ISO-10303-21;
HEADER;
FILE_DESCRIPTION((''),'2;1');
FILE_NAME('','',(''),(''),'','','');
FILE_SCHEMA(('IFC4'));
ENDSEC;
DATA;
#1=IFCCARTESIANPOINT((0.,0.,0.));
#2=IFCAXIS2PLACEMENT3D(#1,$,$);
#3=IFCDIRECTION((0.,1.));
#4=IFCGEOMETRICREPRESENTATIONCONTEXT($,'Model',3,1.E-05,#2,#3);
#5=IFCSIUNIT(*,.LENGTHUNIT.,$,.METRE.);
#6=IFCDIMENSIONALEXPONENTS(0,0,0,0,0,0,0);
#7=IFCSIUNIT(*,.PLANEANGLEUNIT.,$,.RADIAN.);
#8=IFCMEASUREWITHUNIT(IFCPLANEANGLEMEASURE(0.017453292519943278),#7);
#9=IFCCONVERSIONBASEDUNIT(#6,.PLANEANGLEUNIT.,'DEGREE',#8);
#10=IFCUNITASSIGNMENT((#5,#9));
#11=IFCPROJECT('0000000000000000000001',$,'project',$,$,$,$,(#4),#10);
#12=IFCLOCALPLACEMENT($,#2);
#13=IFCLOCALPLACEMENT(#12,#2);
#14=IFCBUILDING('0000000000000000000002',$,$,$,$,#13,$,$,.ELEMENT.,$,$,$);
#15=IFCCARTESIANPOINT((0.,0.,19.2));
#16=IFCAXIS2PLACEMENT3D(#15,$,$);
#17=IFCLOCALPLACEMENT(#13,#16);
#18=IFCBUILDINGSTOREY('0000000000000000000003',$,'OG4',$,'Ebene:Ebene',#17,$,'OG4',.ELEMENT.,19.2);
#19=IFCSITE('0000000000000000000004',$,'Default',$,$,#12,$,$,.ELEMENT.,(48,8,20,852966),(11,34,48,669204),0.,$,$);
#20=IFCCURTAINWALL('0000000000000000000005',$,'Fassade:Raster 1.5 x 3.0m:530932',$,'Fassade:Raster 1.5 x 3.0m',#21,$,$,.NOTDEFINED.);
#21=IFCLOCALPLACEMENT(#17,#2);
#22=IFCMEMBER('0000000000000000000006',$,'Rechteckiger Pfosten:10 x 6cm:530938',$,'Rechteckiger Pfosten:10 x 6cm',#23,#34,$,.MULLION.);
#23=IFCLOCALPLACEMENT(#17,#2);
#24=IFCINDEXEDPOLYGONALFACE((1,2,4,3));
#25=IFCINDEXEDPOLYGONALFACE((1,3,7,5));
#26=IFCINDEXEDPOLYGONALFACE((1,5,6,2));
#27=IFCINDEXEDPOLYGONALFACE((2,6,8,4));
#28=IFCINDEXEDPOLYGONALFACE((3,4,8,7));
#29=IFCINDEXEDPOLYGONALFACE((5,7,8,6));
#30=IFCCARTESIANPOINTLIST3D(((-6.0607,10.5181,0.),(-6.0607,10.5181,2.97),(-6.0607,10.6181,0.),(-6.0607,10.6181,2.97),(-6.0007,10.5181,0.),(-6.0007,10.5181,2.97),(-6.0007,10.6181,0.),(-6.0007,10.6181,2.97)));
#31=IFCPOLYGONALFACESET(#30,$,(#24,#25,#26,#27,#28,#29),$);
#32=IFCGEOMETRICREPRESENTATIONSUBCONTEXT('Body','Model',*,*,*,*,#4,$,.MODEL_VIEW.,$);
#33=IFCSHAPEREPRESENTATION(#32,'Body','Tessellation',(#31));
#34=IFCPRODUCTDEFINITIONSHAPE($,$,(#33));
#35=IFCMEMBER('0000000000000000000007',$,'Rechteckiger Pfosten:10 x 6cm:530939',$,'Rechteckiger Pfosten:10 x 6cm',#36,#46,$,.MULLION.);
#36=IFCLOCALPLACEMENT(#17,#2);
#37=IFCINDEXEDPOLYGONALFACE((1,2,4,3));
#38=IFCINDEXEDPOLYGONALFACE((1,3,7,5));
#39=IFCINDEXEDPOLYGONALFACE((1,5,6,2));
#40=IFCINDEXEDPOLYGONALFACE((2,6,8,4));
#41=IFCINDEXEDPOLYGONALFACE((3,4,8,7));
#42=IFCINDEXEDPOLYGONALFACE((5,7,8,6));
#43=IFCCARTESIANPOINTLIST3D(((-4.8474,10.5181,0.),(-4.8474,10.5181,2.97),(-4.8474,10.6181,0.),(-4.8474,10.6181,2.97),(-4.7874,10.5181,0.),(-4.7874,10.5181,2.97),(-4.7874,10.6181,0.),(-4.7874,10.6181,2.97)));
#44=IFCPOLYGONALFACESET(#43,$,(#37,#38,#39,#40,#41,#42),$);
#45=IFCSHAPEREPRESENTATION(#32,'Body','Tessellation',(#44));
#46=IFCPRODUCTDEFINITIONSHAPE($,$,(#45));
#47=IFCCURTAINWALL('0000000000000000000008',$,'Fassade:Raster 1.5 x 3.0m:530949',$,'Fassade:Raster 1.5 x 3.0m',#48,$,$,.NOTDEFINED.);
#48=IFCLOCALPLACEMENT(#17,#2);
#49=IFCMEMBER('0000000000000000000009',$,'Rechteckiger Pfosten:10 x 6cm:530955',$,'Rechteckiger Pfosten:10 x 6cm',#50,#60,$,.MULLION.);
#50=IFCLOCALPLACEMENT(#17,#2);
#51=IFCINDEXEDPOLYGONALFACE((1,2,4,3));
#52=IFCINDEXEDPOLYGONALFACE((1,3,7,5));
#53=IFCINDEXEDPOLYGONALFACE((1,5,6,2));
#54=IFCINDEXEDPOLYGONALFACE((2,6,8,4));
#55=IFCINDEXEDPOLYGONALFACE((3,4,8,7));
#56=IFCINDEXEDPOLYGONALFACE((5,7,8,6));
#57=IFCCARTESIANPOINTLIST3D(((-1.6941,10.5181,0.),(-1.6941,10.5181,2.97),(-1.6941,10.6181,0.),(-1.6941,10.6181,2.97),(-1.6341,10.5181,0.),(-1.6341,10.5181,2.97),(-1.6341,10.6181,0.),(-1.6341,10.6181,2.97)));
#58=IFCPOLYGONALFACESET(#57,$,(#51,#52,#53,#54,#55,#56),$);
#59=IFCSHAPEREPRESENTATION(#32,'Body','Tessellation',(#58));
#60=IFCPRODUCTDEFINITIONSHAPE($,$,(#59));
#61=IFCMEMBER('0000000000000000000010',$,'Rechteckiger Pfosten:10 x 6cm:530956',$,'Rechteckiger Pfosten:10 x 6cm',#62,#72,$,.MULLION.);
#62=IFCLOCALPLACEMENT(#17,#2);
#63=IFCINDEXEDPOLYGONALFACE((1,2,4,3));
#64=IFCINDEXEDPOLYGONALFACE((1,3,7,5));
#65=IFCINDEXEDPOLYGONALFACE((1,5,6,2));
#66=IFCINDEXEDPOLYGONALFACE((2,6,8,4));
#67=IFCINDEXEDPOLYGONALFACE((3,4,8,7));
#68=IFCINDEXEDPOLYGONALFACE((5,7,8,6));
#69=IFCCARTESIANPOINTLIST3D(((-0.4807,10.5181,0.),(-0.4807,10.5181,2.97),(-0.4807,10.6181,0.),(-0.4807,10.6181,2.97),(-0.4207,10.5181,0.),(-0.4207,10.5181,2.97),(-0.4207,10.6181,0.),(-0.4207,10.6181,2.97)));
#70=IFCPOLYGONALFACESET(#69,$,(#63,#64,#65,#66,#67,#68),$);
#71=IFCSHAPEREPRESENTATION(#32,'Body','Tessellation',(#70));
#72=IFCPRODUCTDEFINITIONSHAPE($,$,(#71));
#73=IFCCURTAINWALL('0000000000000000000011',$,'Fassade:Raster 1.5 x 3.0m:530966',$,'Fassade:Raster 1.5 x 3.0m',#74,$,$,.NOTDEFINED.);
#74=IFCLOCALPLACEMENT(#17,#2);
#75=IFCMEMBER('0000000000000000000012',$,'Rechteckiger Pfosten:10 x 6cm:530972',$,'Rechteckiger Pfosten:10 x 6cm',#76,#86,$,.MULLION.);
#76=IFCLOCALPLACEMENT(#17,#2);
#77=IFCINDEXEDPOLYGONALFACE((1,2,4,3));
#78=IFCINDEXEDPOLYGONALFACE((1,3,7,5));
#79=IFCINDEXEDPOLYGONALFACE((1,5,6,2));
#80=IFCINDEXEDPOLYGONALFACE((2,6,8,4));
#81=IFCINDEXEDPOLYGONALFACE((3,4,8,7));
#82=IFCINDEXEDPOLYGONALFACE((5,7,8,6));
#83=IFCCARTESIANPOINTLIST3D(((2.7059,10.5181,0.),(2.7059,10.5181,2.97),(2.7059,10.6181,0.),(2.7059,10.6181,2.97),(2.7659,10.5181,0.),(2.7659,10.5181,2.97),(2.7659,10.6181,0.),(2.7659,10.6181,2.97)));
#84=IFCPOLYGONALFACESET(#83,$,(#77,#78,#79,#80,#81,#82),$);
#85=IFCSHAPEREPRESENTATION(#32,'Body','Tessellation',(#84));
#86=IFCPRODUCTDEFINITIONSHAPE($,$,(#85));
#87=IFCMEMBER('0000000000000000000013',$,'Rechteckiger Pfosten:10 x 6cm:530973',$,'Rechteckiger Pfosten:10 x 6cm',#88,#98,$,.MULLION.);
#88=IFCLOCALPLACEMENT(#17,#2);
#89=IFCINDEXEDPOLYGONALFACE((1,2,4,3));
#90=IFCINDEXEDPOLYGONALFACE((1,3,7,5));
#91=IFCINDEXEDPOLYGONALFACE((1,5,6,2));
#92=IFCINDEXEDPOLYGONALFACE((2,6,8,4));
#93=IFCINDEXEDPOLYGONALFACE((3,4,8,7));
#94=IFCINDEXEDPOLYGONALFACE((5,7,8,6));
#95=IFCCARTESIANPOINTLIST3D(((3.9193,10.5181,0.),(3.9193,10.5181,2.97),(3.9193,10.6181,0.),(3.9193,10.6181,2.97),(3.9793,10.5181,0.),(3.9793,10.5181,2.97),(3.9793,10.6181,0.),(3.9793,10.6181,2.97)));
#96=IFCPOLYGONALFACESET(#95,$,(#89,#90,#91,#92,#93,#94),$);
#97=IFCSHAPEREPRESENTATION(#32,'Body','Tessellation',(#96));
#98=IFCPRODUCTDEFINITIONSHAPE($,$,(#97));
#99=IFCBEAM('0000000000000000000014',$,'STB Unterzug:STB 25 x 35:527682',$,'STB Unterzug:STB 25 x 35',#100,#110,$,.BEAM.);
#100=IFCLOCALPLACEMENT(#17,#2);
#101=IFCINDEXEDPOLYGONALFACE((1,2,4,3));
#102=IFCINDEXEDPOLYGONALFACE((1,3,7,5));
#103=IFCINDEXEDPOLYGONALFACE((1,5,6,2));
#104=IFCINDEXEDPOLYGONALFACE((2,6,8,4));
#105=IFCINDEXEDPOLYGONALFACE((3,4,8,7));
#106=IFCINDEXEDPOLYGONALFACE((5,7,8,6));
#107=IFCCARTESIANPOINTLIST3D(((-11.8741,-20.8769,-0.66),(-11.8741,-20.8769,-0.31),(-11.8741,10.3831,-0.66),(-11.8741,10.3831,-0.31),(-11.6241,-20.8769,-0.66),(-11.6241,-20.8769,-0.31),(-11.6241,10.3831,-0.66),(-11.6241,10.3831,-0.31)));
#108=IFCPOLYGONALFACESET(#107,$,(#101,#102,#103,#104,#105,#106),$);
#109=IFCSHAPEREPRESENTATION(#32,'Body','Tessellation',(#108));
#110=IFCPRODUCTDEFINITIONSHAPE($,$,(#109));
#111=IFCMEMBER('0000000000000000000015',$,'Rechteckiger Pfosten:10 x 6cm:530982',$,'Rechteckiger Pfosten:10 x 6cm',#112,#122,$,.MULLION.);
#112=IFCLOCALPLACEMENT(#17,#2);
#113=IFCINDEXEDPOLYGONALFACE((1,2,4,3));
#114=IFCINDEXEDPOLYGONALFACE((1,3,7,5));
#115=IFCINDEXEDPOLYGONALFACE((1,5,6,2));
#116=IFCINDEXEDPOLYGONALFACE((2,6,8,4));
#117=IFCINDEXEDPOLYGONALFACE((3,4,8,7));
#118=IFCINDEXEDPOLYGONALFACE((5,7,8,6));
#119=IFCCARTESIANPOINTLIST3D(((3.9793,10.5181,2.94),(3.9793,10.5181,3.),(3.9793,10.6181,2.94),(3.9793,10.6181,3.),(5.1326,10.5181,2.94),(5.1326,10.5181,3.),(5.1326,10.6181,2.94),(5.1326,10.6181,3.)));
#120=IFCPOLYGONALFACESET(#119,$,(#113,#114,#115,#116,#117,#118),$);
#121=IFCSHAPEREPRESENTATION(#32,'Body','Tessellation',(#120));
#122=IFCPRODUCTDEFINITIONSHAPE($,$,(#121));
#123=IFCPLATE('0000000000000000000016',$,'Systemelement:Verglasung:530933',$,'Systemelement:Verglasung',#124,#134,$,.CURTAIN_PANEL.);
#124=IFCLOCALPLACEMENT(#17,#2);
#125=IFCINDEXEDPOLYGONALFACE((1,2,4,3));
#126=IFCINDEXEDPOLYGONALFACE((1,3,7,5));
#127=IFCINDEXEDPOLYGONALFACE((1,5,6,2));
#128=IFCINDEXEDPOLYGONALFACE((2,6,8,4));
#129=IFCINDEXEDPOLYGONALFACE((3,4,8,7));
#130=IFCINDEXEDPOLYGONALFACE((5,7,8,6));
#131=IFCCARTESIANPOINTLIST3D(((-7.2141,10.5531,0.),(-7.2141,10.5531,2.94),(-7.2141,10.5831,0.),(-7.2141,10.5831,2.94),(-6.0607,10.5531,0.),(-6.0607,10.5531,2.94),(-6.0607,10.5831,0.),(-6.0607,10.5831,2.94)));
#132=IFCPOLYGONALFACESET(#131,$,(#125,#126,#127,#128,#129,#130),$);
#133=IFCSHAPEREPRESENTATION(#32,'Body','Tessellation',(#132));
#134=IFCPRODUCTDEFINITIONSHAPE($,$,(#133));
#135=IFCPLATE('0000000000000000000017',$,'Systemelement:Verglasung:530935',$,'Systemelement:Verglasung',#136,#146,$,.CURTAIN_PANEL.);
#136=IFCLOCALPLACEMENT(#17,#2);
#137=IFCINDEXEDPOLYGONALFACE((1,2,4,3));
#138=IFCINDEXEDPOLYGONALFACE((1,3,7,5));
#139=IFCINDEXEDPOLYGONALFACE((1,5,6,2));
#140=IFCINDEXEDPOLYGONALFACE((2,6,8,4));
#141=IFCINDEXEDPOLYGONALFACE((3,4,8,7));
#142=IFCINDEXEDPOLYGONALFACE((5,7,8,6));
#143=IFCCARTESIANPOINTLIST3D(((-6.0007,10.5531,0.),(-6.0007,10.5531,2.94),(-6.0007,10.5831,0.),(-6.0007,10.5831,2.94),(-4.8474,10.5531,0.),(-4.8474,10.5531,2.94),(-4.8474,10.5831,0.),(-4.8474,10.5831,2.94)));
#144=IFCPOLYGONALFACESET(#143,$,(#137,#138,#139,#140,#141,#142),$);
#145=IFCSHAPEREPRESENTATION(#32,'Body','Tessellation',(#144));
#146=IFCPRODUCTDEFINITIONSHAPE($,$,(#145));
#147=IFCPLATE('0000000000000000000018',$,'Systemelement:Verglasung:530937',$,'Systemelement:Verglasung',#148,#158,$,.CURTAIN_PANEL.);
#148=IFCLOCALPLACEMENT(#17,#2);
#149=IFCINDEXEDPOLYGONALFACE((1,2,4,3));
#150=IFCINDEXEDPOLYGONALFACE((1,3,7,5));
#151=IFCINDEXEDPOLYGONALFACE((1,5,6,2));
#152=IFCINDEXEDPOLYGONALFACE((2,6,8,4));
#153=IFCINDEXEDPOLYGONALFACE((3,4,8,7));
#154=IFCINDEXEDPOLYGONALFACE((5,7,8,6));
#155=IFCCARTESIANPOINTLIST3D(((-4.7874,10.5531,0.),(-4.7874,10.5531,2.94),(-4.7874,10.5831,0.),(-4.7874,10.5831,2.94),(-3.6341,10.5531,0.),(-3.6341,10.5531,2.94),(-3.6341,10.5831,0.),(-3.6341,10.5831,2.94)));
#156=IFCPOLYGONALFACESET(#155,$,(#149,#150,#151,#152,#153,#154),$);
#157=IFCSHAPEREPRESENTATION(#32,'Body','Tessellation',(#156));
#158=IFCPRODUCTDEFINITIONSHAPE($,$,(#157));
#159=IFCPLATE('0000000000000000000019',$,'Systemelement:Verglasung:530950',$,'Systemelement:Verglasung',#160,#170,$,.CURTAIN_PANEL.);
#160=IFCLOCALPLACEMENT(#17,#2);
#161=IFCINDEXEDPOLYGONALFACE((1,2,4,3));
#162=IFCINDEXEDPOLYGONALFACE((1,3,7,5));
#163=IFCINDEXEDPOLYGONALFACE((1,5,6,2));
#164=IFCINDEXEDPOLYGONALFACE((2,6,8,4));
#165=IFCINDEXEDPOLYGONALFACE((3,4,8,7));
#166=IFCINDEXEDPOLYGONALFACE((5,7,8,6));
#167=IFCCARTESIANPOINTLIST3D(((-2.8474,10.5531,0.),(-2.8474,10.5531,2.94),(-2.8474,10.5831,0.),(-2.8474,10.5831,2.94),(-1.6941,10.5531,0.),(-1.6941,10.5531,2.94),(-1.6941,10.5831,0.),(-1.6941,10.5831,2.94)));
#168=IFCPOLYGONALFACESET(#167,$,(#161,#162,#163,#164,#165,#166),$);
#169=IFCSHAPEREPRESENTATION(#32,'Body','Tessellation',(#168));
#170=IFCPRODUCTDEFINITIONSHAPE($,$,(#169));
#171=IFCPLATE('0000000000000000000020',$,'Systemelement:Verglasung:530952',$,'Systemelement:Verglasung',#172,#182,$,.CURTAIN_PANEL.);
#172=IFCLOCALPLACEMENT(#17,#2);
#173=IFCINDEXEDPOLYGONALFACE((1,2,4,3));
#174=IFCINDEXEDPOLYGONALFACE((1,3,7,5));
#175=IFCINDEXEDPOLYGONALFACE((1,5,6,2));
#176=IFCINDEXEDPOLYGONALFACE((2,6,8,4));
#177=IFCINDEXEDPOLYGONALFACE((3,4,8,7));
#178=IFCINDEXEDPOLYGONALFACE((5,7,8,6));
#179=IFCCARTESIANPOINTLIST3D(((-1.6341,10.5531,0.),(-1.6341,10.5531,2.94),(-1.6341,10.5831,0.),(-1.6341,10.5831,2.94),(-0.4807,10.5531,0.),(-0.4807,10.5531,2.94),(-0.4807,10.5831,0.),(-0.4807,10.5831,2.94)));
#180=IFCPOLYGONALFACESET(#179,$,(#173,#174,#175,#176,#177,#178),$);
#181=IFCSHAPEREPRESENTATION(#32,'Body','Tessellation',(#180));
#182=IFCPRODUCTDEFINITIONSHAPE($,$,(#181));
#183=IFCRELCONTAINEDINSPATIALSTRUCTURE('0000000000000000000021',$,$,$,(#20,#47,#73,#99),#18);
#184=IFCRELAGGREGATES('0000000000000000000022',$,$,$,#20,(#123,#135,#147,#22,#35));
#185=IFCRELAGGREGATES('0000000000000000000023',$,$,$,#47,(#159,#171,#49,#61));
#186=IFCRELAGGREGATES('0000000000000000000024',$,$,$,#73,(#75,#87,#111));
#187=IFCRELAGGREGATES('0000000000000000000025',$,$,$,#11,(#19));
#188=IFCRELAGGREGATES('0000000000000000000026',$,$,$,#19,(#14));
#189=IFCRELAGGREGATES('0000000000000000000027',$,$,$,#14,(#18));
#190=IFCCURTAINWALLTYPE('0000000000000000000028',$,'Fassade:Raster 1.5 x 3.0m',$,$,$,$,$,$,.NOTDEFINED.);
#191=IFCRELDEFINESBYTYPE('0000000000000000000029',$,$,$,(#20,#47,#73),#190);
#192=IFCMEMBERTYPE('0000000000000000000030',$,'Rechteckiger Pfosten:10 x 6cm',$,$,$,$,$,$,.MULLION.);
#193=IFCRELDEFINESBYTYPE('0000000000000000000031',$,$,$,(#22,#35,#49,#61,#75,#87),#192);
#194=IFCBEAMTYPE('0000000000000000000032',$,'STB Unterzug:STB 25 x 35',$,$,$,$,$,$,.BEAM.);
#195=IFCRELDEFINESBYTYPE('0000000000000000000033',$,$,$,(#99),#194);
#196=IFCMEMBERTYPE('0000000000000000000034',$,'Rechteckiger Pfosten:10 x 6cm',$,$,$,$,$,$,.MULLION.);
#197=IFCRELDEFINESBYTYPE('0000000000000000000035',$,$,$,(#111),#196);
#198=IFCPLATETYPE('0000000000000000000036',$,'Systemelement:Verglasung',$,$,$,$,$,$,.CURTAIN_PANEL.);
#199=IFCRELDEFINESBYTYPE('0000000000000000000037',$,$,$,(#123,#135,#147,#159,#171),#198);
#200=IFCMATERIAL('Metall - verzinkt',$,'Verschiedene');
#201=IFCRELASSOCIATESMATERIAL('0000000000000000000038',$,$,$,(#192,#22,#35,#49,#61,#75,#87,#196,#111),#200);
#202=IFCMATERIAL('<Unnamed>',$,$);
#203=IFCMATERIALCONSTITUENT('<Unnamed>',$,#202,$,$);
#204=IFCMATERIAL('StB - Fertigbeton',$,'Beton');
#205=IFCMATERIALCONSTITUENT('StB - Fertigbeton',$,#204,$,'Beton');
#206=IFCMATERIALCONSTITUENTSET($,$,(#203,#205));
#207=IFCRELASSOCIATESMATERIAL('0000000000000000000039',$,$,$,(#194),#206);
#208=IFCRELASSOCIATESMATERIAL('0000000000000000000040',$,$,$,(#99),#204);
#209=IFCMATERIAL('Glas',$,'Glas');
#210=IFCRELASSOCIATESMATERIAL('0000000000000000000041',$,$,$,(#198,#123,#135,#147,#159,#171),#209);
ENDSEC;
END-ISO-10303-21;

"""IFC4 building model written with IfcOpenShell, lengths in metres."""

from ifc_helpers import new_model, entity, si_unit, converted_unit, direction, frame, origin, place, context, subcontext, project, spatial, indexed_curve, outline, extrude, source, transform, mapped, material, constituent, constituent_set, type_object, type_shapes, element, aggregate, save


model = new_model("IFC4")

# Units and contexts
model_context = context("Model", 3, precision=1e-05, world=origin(), true_north=direction((0.0, 1.0)))
body_context = subcontext(model_context, "Body", "Model", "MODEL_VIEW")
ifc_project = project(units=[si_unit("LENGTHUNIT", "METRE"), converted_unit("PLANEANGLEUNIT", "DEGREE", entity("IfcPlaneAngleMeasure", 0.017453292519943278), si_unit("PLANEANGLEUNIT", "RADIAN"), dimensions=[0, 0, 0, 0, 0, 0, 0])], contexts=[model_context])

# Site, building, storey
site_placement = place(None, origin())
site = spatial("IfcSite", under=ifc_project, at=site_placement, Name="Default", CompositionType="ELEMENT", RefLatitude=(48, 8, 20, 852966), RefLongitude=(11, 34, 48, 669204), RefElevation=0.0)
building_placement = place(site_placement, origin())
building = spatial("IfcBuilding", under=site, at=building_placement, CompositionType="ELEMENT")
storey_placement = place(building_placement, frame((0.0, 0.0, 19.2)))
storey = spatial("IfcBuildingStorey", under=building, at=storey_placement, Name="OG4", ObjectType="Ebene:Ebene", LongName="OG4", CompositionType="ELEMENT", Elevation=19.2)

# Curtain walls, members
curtain_wall_type = type_object("IfcCurtainWallType", Name="Fassade:Raster 1.5 x 3.0m", PredefinedType="NOTDEFINED")
curtain_wall_1_placement = place(storey_placement, frame((0.0, 0.0, -19.2)))
curtain_wall_1 = element("IfcCurtainWall", 1, at=curtain_wall_1_placement, inside=storey, type_object=curtain_wall_type, Name="Fassade:Raster 1.5 x 3.0m:530932", ObjectType="Fassade:Raster 1.5 x 3.0m", PredefinedType="NOTDEFINED")
ifc_material_1 = material(Name="Metall - verzinkt", Category="Verschiedene")
member_type_1 = type_object("IfcMemberType", Name="Rechteckiger Pfosten:10 x 6cm", PredefinedType="MULLION", material=ifc_material_1)
shared_shape_1 = source(origin(), body_context, "Body", "SweptSolid", [
    extrude(outline(indexed_curve([(-0.03, -0.05), (0.03, -0.05), (0.03, 0.05), (-0.03, 0.05), (-0.03, -0.05)], self_intersect=False)), frame((0.0, 0.0, -2.97), z_axis=(0.0, 0.0, 1.0), x_axis=(-1.0, 0.0, 0.0)), (0.0, 0.0, 1.0), 2.97),
])
type_shapes(member_type_1, [shared_shape_1])
member_1_placement = place(curtain_wall_1_placement, frame((-6.0307, 10.5681, 19.2), z_axis=(0.0, 0.0, -1.0), x_axis=(1.0, 0.0, 0.0)))
member_1 = element("IfcMember", 2, at=member_1_placement, type_object=member_type_1, material=ifc_material_1, Name="Rechteckiger Pfosten:10 x 6cm:530938", ObjectType="Rechteckiger Pfosten:10 x 6cm", PredefinedType="MULLION", context=body_context, shape_type="MappedRepresentation", body=[
    mapped(shared_shape_1, transform((0.0, 0.0, 0.0), scale=1.0)),
])
member_2_placement = place(curtain_wall_1_placement, frame((-4.8174, 10.5681, 19.2), z_axis=(0.0, 0.0, -1.0), x_axis=(1.0, 0.0, 0.0)))
member_2 = element("IfcMember", 3, at=member_2_placement, type_object=member_type_1, material=ifc_material_1, Name="Rechteckiger Pfosten:10 x 6cm:530939", ObjectType="Rechteckiger Pfosten:10 x 6cm", PredefinedType="MULLION", context=body_context, shape_type="MappedRepresentation", body=[
    mapped(shared_shape_1, transform((0.0, 0.0, 0.0), scale=1.0)),
])
curtain_wall_2_placement = place(storey_placement, frame((0.0, 0.0, -19.2)))
curtain_wall_2 = element("IfcCurtainWall", 4, at=curtain_wall_2_placement, inside=storey, type_object=curtain_wall_type, Name="Fassade:Raster 1.5 x 3.0m:530949", ObjectType="Fassade:Raster 1.5 x 3.0m", PredefinedType="NOTDEFINED")
member_3_placement = place(curtain_wall_2_placement, frame((-1.6641, 10.5681, 19.2), z_axis=(0.0, 0.0, -1.0), x_axis=(1.0, 0.0, 0.0)))
member_3 = element("IfcMember", 5, at=member_3_placement, type_object=member_type_1, material=ifc_material_1, Name="Rechteckiger Pfosten:10 x 6cm:530955", ObjectType="Rechteckiger Pfosten:10 x 6cm", PredefinedType="MULLION", context=body_context, shape_type="MappedRepresentation", body=[
    mapped(shared_shape_1, transform((0.0, 0.0, 0.0), scale=1.0)),
])
member_4_placement = place(curtain_wall_2_placement, frame((-0.4507, 10.5681, 19.2), z_axis=(0.0, 0.0, -1.0), x_axis=(1.0, 0.0, 0.0)))
member_4 = element("IfcMember", 6, at=member_4_placement, type_object=member_type_1, material=ifc_material_1, Name="Rechteckiger Pfosten:10 x 6cm:530956", ObjectType="Rechteckiger Pfosten:10 x 6cm", PredefinedType="MULLION", context=body_context, shape_type="MappedRepresentation", body=[
    mapped(shared_shape_1, transform((0.0, 0.0, 0.0), scale=1.0)),
])
curtain_wall_3_placement = place(storey_placement, frame((0.0, 0.0, -19.2)))
curtain_wall_3 = element("IfcCurtainWall", 7, at=curtain_wall_3_placement, inside=storey, type_object=curtain_wall_type, Name="Fassade:Raster 1.5 x 3.0m:530966", ObjectType="Fassade:Raster 1.5 x 3.0m", PredefinedType="NOTDEFINED")
member_5_placement = place(curtain_wall_3_placement, frame((2.7359, 10.5681, 19.2), z_axis=(0.0, 0.0, -1.0), x_axis=(1.0, 0.0, 0.0)))
member_5 = element("IfcMember", 8, at=member_5_placement, type_object=member_type_1, material=ifc_material_1, Name="Rechteckiger Pfosten:10 x 6cm:530972", ObjectType="Rechteckiger Pfosten:10 x 6cm", PredefinedType="MULLION", context=body_context, shape_type="MappedRepresentation", body=[
    mapped(shared_shape_1, transform((0.0, 0.0, 0.0), scale=1.0)),
])
member_6_placement = place(curtain_wall_3_placement, frame((3.9493, 10.5681, 19.2), z_axis=(0.0, 0.0, -1.0), x_axis=(1.0, 0.0, 0.0)))
member_6 = element("IfcMember", 9, at=member_6_placement, type_object=member_type_1, material=ifc_material_1, Name="Rechteckiger Pfosten:10 x 6cm:530973", ObjectType="Rechteckiger Pfosten:10 x 6cm", PredefinedType="MULLION", context=body_context, shape_type="MappedRepresentation", body=[
    mapped(shared_shape_1, transform((0.0, 0.0, 0.0), scale=1.0)),
])

# Beam
ifc_material_2 = material(Name="StB - Fertigbeton", Category="Beton")
ifc_material_3 = material(Name="<Unnamed>")
ifc_constituent_1 = constituent(ifc_material_3, Name="<Unnamed>")
ifc_constituent_2 = constituent(ifc_material_2, Name="StB - Fertigbeton", Category="Beton")
ifc_constituent_set_1 = constituent_set(constituents=[ifc_constituent_1, ifc_constituent_2])
beam_type = type_object("IfcBeamType", Name="STB Unterzug:STB 25 x 35", PredefinedType="BEAM", material=ifc_constituent_set_1)
shared_shape_2 = source(origin(), body_context, "Body", "SweptSolid", [
    extrude(outline(indexed_curve([(-0.125, -0.175), (0.125, -0.175), (0.125, 0.175), (-0.125, 0.175), (-0.125, -0.175)], self_intersect=False)), frame((-11.7491, 10.3831, 18.715), z_axis=(0.0, -1.0, 0.0), x_axis=(-1.0, 0.0, 0.0)), (0.0, 0.0, 1.0), 31.26),
])
type_shapes(beam_type, [shared_shape_2])
beam_placement = place(storey_placement, frame((0.0, 0.0, -19.2)))
element("IfcBeam", 10, at=beam_placement, inside=storey, type_object=beam_type, material=ifc_material_2, Name="STB Unterzug:STB 25 x 35:527682", ObjectType="STB Unterzug:STB 25 x 35", PredefinedType="BEAM", context=body_context, shape_type="MappedRepresentation", body=[
    mapped(shared_shape_2, transform((0.0, 0.0, 0.0), scale=1.0)),
])

# Member
member_type_2 = type_object("IfcMemberType", Name="Rechteckiger Pfosten:10 x 6cm", PredefinedType="MULLION", material=ifc_material_1)
shared_shape_3 = source(origin(), body_context, "Body", "SweptSolid", [
    extrude(outline(indexed_curve([(-0.03, -0.05), (0.03, -0.05), (0.03, 0.05), (-0.03, 0.05), (-0.03, -0.05)], self_intersect=False)), frame((0.0, 0.0, -1.1533), z_axis=(0.0, 0.0, 1.0), x_axis=(-1.0, 0.0, 0.0)), (0.0, 0.0, 1.0), 1.1533),
])
type_shapes(member_type_2, [shared_shape_3])
member_7_placement = place(curtain_wall_3_placement, frame((5.1326, 10.5681, 22.17), z_axis=(1.0, 0.0, 0.0), x_axis=(0.0, 0.0, 1.0)))
member_7 = element("IfcMember", 11, at=member_7_placement, type_object=member_type_2, material=ifc_material_1, Name="Rechteckiger Pfosten:10 x 6cm:530982", ObjectType="Rechteckiger Pfosten:10 x 6cm", PredefinedType="MULLION", context=body_context, shape_type="MappedRepresentation", body=[
    mapped(shared_shape_3, transform((0.0, 0.0, 0.0), scale=1.0)),
])

# Plates
ifc_material_4 = material(Name="Glas", Category="Glas")
plate_type = type_object("IfcPlateType", Name="Systemelement:Verglasung", PredefinedType="CURTAIN_PANEL", material=ifc_material_4)
shared_shape_4 = source(origin(), body_context, "Body", "SweptSolid", [
    extrude(outline(indexed_curve([(-0.015, -0.5767), (0.015, -0.5767), (0.015, 0.5767), (-0.015, 0.5767), (-0.015, -0.5767)], self_intersect=False)), frame((0.0, 0.0, 0.0), z_axis=(0.0, 0.0, 1.0), x_axis=(0.0, 1.0, 0.0)), (0.0, 0.0, 1.0), 2.94),
])
type_shapes(plate_type, [shared_shape_4])
plate_1_placement = place(curtain_wall_1_placement, frame((-6.6374, 10.5681, 19.2)))
plate_1 = element("IfcPlate", 12, at=plate_1_placement, type_object=plate_type, material=ifc_material_4, Name="Systemelement:Verglasung:530933", ObjectType="Systemelement:Verglasung", PredefinedType="CURTAIN_PANEL", context=body_context, shape_type="MappedRepresentation", body=[
    mapped(shared_shape_4, transform((0.0, 0.0, 0.0), scale=1.0)),
])
plate_2_placement = place(curtain_wall_1_placement, frame((-5.4241, 10.5681, 19.2)))
plate_2 = element("IfcPlate", 13, at=plate_2_placement, type_object=plate_type, material=ifc_material_4, Name="Systemelement:Verglasung:530935", ObjectType="Systemelement:Verglasung", PredefinedType="CURTAIN_PANEL", context=body_context, shape_type="MappedRepresentation", body=[
    mapped(shared_shape_4, transform((0.0, 0.0, 0.0), scale=1.0)),
])
plate_3_placement = place(curtain_wall_1_placement, frame((-4.2107, 10.5681, 19.2)))
plate_3 = element("IfcPlate", 14, at=plate_3_placement, type_object=plate_type, material=ifc_material_4, Name="Systemelement:Verglasung:530937", ObjectType="Systemelement:Verglasung", PredefinedType="CURTAIN_PANEL", context=body_context, shape_type="MappedRepresentation", body=[
    mapped(shared_shape_4, transform((0.0, 0.0, 0.0), scale=1.0)),
])
aggregate(curtain_wall_1, [plate_1, plate_2, plate_3, member_1, member_2])
plate_4_placement = place(curtain_wall_2_placement, frame((-2.2707, 10.5681, 19.2)))
plate_4 = element("IfcPlate", 15, at=plate_4_placement, type_object=plate_type, material=ifc_material_4, Name="Systemelement:Verglasung:530950", ObjectType="Systemelement:Verglasung", PredefinedType="CURTAIN_PANEL", context=body_context, shape_type="MappedRepresentation", body=[
    mapped(shared_shape_4, transform((0.0, 0.0, 0.0), scale=1.0)),
])
plate_5_placement = place(curtain_wall_2_placement, frame((-1.0574, 10.5681, 19.2)))
plate_5 = element("IfcPlate", 16, at=plate_5_placement, type_object=plate_type, material=ifc_material_4, Name="Systemelement:Verglasung:530952", ObjectType="Systemelement:Verglasung", PredefinedType="CURTAIN_PANEL", context=body_context, shape_type="MappedRepresentation", body=[
    mapped(shared_shape_4, transform((0.0, 0.0, 0.0), scale=1.0)),
])
aggregate(curtain_wall_2, [plate_4, plate_5, member_3, member_4])
aggregate(curtain_wall_3, [member_5, member_6, member_7])

save(model, "model.ifc")
